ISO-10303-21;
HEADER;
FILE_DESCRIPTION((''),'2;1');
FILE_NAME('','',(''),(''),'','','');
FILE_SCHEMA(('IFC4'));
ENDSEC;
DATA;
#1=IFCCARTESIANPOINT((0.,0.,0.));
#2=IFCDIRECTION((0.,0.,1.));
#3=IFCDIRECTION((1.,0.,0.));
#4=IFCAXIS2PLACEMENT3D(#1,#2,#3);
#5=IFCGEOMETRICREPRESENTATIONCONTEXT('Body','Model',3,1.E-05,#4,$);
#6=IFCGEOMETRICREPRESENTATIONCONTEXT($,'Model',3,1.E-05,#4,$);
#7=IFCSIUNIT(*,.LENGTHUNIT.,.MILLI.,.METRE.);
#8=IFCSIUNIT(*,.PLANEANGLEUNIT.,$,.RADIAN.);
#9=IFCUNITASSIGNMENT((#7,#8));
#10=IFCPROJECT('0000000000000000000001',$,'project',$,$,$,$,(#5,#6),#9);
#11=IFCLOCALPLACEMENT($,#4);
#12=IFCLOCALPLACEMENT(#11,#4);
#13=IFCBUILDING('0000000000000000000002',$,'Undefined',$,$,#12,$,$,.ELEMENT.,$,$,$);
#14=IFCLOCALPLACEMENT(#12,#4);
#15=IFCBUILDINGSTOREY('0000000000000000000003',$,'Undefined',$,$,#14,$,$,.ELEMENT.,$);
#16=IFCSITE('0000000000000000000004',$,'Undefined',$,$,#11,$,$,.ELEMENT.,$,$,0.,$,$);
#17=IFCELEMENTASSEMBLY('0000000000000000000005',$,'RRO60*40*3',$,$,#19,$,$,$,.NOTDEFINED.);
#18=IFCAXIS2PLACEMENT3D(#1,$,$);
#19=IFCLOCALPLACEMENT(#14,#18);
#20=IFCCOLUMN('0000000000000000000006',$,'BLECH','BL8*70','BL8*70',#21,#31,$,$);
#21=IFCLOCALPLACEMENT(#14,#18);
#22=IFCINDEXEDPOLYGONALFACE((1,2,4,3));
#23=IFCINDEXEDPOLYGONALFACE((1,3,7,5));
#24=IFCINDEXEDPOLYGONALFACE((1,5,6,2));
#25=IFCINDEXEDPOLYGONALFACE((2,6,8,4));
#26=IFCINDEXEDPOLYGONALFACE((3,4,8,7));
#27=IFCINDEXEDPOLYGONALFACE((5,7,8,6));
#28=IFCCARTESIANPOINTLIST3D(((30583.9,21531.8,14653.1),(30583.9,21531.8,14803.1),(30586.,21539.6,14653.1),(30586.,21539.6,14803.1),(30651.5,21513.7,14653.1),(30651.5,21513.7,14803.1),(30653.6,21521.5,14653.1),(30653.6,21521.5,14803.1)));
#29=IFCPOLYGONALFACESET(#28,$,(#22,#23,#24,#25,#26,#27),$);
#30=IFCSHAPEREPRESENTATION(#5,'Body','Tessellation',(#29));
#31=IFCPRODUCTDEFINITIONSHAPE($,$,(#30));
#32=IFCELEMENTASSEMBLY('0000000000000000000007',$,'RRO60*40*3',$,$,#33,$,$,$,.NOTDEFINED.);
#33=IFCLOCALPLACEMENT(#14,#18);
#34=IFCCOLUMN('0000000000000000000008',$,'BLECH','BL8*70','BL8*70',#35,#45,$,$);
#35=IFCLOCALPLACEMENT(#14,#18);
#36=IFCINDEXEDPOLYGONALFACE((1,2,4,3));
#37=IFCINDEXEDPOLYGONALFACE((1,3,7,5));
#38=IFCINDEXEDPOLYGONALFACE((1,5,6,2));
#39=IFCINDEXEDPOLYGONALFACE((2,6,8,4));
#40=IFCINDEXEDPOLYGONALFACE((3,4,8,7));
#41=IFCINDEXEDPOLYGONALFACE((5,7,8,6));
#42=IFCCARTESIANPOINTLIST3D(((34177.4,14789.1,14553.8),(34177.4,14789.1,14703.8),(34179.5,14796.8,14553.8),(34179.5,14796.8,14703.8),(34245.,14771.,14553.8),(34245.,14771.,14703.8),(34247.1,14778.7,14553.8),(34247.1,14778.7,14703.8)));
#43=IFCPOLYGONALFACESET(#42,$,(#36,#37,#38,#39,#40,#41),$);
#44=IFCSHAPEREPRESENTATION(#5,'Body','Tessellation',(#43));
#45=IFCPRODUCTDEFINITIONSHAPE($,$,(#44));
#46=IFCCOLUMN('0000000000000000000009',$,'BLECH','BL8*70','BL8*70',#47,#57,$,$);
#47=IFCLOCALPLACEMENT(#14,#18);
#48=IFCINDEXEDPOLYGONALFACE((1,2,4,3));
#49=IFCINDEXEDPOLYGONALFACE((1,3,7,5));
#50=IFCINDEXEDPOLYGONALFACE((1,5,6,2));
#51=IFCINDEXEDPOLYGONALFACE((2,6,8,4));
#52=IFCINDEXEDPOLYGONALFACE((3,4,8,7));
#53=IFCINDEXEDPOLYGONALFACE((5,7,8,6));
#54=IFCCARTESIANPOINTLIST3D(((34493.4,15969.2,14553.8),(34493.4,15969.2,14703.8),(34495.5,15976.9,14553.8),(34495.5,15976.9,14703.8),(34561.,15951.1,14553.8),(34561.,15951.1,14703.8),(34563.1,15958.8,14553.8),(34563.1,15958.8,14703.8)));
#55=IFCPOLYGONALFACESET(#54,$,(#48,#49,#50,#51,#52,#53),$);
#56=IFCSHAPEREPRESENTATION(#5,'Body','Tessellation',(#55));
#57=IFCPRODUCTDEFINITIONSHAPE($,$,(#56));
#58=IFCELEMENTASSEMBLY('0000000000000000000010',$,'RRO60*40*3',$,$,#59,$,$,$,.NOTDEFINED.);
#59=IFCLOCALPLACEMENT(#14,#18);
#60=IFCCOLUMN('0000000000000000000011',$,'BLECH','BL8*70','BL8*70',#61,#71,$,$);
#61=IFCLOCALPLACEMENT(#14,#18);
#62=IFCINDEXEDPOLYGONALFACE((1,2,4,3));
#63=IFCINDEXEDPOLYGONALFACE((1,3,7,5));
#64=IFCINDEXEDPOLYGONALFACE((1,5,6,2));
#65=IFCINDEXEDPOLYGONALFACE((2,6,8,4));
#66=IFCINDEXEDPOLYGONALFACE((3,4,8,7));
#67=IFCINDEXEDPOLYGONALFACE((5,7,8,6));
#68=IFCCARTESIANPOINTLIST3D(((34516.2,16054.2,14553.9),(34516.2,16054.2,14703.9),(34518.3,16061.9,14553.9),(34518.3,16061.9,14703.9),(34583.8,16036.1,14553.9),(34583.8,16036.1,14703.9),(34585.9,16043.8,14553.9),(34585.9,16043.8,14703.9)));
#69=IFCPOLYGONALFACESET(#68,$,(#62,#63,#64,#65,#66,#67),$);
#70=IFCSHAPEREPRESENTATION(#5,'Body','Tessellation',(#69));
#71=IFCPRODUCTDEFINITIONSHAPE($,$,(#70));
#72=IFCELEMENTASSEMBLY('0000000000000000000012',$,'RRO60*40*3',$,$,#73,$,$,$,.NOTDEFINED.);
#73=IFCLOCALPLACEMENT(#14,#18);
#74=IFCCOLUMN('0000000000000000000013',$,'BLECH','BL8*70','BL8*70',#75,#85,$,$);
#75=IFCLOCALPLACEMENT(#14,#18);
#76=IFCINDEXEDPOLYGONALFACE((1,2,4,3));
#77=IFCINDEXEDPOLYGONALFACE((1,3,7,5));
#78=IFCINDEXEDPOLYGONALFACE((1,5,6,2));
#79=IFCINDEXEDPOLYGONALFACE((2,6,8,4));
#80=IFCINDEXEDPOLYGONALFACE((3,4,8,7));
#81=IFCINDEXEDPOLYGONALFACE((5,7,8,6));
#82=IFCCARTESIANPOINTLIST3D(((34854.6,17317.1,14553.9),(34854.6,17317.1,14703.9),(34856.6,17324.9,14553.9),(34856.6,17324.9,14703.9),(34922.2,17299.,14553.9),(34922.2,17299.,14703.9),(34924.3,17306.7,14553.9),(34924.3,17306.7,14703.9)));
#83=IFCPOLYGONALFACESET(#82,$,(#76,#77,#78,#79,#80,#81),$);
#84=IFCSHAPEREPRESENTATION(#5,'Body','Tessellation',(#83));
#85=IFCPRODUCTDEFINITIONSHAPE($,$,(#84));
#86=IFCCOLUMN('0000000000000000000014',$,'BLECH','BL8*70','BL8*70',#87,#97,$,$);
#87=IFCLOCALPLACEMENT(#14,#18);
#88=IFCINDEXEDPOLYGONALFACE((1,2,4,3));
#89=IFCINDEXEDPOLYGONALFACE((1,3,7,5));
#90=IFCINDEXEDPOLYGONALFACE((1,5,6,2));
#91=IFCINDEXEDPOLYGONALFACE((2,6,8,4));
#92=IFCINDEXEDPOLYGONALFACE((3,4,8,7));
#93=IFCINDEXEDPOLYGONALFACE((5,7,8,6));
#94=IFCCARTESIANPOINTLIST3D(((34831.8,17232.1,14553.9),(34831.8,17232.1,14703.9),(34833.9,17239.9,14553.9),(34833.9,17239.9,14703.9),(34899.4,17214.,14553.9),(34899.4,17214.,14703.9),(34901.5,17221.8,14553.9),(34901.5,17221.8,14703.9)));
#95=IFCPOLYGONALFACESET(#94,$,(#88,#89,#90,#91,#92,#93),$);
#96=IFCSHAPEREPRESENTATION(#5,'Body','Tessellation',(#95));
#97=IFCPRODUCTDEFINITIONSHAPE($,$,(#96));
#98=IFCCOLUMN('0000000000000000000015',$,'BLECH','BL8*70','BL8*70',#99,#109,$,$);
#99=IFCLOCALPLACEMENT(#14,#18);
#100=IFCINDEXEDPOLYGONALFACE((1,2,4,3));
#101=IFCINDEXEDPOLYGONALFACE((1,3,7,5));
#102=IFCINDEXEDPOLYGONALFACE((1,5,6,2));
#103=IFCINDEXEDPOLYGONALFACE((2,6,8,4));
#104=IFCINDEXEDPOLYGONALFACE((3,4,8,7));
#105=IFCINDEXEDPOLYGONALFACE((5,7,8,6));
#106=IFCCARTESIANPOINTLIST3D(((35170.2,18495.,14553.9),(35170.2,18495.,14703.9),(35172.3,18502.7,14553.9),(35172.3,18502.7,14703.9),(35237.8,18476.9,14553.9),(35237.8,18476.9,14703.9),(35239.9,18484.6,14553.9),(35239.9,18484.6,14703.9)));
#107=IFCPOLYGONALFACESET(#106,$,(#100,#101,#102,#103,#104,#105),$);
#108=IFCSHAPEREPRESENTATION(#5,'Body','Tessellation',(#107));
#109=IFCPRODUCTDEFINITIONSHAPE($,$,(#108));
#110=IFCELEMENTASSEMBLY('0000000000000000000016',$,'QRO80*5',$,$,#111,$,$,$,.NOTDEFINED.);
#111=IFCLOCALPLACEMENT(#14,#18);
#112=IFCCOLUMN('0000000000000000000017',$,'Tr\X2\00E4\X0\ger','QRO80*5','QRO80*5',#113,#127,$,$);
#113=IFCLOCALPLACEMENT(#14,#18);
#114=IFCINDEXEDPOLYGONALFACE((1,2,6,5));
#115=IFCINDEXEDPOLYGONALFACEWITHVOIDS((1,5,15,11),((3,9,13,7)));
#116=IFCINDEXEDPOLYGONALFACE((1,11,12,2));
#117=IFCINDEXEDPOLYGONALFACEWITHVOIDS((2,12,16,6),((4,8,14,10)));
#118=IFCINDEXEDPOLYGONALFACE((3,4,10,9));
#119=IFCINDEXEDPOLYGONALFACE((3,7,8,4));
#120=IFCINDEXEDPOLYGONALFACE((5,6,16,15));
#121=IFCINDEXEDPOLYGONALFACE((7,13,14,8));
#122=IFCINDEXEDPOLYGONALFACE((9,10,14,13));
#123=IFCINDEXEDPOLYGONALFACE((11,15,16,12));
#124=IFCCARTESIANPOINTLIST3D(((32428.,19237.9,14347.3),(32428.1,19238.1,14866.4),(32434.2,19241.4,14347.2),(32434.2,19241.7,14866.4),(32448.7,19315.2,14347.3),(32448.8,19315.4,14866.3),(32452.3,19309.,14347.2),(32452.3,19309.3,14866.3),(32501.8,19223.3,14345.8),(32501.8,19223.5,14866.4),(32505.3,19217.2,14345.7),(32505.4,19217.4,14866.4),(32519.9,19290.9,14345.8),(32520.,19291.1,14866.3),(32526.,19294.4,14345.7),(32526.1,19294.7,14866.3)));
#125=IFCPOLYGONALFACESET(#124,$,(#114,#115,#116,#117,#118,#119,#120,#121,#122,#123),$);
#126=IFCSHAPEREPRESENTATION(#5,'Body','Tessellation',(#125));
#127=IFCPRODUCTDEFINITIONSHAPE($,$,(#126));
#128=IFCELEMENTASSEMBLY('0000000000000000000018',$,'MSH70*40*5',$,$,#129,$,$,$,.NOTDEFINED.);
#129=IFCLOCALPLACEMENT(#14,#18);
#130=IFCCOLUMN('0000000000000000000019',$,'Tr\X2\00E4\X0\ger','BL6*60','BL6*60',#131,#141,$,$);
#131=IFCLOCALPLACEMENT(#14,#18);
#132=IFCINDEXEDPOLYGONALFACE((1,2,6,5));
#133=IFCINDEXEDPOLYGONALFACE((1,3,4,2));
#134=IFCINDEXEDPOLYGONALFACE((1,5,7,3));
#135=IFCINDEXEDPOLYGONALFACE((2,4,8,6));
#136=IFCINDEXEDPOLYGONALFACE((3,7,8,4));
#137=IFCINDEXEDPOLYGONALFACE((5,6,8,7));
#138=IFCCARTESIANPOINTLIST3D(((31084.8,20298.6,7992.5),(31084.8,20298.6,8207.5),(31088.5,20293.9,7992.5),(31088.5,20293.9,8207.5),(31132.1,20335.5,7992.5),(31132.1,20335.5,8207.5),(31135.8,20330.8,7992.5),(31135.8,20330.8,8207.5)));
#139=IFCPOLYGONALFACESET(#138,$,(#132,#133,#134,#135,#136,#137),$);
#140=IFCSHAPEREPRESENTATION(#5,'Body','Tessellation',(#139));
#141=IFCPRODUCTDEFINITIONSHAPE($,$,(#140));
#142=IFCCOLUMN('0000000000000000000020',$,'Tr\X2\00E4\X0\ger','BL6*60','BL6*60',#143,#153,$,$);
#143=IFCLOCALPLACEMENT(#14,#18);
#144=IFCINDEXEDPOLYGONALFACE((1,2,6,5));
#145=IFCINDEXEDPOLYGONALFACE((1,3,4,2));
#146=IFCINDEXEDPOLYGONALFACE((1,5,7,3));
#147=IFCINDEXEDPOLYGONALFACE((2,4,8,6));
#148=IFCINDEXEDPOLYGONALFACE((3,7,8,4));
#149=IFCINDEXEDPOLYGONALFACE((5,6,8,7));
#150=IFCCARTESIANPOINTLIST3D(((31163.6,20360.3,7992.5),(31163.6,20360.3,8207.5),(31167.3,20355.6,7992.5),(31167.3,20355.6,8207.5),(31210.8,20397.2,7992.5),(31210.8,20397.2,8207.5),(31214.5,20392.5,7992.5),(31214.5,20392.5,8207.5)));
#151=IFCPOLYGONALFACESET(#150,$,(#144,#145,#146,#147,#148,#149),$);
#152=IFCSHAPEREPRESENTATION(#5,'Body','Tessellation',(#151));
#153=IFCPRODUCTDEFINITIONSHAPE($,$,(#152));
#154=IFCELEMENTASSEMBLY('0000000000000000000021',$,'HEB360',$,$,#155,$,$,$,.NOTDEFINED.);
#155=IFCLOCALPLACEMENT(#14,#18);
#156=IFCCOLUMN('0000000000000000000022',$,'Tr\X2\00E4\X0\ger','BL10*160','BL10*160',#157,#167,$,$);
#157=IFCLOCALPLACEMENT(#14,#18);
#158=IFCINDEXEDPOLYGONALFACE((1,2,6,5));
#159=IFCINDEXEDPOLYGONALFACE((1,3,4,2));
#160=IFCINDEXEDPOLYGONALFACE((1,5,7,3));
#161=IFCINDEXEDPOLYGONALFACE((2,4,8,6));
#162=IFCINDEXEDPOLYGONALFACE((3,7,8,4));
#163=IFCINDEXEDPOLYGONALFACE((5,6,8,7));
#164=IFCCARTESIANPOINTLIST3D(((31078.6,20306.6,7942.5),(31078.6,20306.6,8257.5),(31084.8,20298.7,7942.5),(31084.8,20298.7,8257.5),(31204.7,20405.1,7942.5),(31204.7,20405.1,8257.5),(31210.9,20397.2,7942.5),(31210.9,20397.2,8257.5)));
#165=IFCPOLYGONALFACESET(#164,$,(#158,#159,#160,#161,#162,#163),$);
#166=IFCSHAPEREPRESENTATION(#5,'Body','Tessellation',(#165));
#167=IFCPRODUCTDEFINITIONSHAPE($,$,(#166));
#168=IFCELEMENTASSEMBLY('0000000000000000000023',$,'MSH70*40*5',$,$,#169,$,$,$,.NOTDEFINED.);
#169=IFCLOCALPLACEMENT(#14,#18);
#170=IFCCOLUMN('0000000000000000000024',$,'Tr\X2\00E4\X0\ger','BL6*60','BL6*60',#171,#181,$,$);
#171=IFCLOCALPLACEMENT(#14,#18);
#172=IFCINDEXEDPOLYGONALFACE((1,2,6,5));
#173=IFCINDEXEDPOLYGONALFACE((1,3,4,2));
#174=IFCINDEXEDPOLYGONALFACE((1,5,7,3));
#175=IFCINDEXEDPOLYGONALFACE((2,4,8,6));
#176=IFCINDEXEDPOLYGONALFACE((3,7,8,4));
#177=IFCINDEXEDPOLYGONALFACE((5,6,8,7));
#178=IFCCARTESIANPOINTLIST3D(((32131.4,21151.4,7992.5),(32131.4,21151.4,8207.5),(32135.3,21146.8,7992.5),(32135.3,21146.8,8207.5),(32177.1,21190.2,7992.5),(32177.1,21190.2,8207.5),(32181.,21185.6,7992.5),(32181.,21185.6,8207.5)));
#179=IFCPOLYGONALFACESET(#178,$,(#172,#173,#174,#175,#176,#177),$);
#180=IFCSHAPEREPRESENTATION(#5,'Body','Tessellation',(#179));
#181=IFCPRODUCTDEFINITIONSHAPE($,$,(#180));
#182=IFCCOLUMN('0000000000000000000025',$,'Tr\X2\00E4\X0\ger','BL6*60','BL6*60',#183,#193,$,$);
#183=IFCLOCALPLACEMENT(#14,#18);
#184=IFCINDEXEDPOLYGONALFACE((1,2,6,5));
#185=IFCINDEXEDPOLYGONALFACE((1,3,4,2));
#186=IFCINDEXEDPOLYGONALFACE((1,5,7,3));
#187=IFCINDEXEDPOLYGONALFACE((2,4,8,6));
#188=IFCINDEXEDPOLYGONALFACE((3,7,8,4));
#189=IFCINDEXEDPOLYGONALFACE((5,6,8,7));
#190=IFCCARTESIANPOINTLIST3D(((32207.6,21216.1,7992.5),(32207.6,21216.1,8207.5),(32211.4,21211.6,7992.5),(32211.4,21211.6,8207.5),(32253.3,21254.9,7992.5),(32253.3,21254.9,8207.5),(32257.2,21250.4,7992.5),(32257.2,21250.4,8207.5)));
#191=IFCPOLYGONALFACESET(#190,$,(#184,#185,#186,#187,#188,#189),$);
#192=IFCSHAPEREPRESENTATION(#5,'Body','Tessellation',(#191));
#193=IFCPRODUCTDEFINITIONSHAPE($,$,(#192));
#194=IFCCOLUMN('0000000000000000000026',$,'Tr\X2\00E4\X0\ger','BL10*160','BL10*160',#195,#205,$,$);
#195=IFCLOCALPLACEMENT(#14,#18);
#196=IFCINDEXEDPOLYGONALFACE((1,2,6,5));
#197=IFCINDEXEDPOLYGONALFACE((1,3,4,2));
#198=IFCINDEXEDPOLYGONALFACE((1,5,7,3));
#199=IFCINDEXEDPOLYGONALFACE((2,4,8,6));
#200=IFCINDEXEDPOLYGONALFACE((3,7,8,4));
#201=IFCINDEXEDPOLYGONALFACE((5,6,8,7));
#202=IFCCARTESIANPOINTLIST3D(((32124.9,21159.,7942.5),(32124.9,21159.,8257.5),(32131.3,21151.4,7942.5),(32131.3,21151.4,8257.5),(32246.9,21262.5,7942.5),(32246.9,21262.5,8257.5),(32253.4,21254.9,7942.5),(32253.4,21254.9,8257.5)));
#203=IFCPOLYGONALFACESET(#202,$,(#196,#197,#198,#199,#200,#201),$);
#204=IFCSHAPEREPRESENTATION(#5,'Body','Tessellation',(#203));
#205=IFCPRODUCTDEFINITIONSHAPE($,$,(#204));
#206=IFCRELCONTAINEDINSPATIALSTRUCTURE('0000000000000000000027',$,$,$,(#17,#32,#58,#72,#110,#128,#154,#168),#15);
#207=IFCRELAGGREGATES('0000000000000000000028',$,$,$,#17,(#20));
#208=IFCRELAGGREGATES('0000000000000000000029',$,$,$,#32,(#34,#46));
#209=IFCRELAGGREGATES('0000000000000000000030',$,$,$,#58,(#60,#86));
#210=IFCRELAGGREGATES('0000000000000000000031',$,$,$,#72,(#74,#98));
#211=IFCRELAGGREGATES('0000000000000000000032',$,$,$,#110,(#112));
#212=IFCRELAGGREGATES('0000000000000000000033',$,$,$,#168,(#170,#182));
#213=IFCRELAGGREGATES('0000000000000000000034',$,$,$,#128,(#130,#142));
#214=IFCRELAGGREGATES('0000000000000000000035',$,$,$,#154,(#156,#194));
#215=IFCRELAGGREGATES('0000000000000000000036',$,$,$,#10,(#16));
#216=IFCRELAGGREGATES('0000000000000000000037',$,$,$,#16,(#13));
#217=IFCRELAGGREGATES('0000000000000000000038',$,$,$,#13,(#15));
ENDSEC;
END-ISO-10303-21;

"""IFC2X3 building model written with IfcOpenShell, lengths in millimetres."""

from ifc_helpers import new_model, si_unit, frame, origin_with_axes, origin_2d_with_axis, place, context, project, spatial, rectangle, hollow_rectangle, extrude, clip, halfspace, element, aggregate, save


model = new_model("IFC2X3")

# Units and contexts
model_context_1 = context("Model", 3, precision=1e-05, world=origin_with_axes(), identifier="Body")
model_context_2 = context("Model", 3, precision=1e-05, world=origin_with_axes())
ifc_project = project(units=[si_unit("LENGTHUNIT", "METRE", prefix="MILLI"), si_unit("PLANEANGLEUNIT", "RADIAN")], contexts=[model_context_1, model_context_2])

# Site, building, storey
site_placement = place(None, origin_with_axes())
site = spatial("IfcSite", under=ifc_project, at=site_placement, Name="Undefined", CompositionType="ELEMENT", RefElevation=0.0)
building_placement = place(site_placement, origin_with_axes())
building = spatial("IfcBuilding", under=site, at=building_placement, Name="Undefined", CompositionType="ELEMENT")
storey_placement = place(building_placement, origin_with_axes())
storey = spatial("IfcBuildingStorey", under=building, at=storey_placement, Name="Undefined", CompositionType="ELEMENT")

# Element assembly, column
assembly_1 = element("IfcElementAssembly", 1, inside=storey, Name="RRO60*40*3", PredefinedType="NOTDEFINED")
column_1_placement = place(storey_placement, frame((30618.7, 21526.7, 14653.1), z_axis=(0.0, 0.0, 1.0), x_axis=(1.0, 0.0, 0.0)))
column_1 = element("IfcColumn", 2, at=column_1_placement, Name="BLECH", Description="BL8*70", ObjectType="BL8*70", context=model_context_1, shape_type="SweptSolid", body=[
    extrude(rectangle(XDim=8.0, YDim=70.0, at=origin_2d_with_axis()), frame((0.0, 0.0, 150.0), z_axis=(0.0, 0.0, -1.0), x_axis=(0.258806, 0.965929, -0.000007)), (0.0, 0.0, 1.0), 150.0),
])
aggregate(assembly_1, [column_1])

# Element assembly, columns
assembly_2 = element("IfcElementAssembly", 3, inside=storey, Name="RRO60*40*3", PredefinedType="NOTDEFINED")
column_2_placement = place(storey_placement, frame((34212.3, 14783.9, 14553.8), z_axis=(0.0, 0.0, 1.0), x_axis=(1.0, 0.0, 0.0)))
column_2 = element("IfcColumn", 4, at=column_2_placement, Name="BLECH", Description="BL8*70", ObjectType="BL8*70", context=model_context_1, shape_type="SweptSolid", body=[
    extrude(rectangle(XDim=8.0, YDim=70.0, at=origin_2d_with_axis()), frame((0.0, 0.0, 150.0), z_axis=(0.0, 0.0, -1.0), x_axis=(0.258667, 0.965967, 0.000006)), (0.0, 0.0, 1.0), 150.0),
])
column_3_placement = place(storey_placement, frame((34528.3, 15964.0, 14553.8), z_axis=(0.0, 0.0, 1.0), x_axis=(1.0, 0.0, 0.0)))
column_3 = element("IfcColumn", 5, at=column_3_placement, Name="BLECH", Description="BL8*70", ObjectType="BL8*70", context=model_context_1, shape_type="SweptSolid", body=[
    extrude(rectangle(XDim=8.0, YDim=70.0, at=origin_2d_with_axis()), frame((0.0, 0.0, 150.0), z_axis=(0.0, 0.0, -1.0), x_axis=(-0.258667, -0.965967, -0.000006)), (0.0, 0.0, 1.0), 150.0),
])
aggregate(assembly_2, [column_2, column_3])

# Element assemblies, columns
assembly_3 = element("IfcElementAssembly", 6, inside=storey, Name="RRO60*40*3", PredefinedType="NOTDEFINED")
column_4_placement = place(storey_placement, frame((34551.0, 16049.0, 14553.9), z_axis=(0.0, 0.0, 1.0), x_axis=(1.0, 0.0, 0.0)))
column_4 = element("IfcColumn", 7, at=column_4_placement, Name="BLECH", Description="BL8*70", ObjectType="BL8*70", context=model_context_1, shape_type="SweptSolid", body=[
    extrude(rectangle(XDim=8.0, YDim=70.0, at=origin_2d_with_axis()), frame((0.0, 0.0, 150.0), z_axis=(0.0, 0.0, -1.0), x_axis=(0.258822, 0.965925, 0.000005)), (0.0, 0.0, 1.0), 150.0),
])
assembly_4 = element("IfcElementAssembly", 8, inside=storey, Name="RRO60*40*3", PredefinedType="NOTDEFINED")
column_5_placement = place(storey_placement, frame((34889.4, 17311.9, 14553.9), z_axis=(0.0, 0.0, 1.0), x_axis=(1.0, 0.0, 0.0)))
column_5 = element("IfcColumn", 9, at=column_5_placement, Name="BLECH", Description="BL8*70", ObjectType="BL8*70", context=model_context_1, shape_type="SweptSolid", body=[
    extrude(rectangle(XDim=8.0, YDim=70.0, at=origin_2d_with_axis()), frame((0.0, 0.0, 150.0), z_axis=(0.0, 0.0, -1.0), x_axis=(0.258822, 0.965925, 0.000005)), (0.0, 0.0, 1.0), 150.0),
])

# Columns
column_6_placement = place(storey_placement, frame((34866.7, 17227.0, 14553.9), z_axis=(0.0, 0.0, 1.0), x_axis=(1.0, 0.0, 0.0)))
column_6 = element("IfcColumn", 10, at=column_6_placement, Name="BLECH", Description="BL8*70", ObjectType="BL8*70", context=model_context_1, shape_type="SweptSolid", body=[
    extrude(rectangle(XDim=8.0, YDim=70.0, at=origin_2d_with_axis()), frame((0.0, 0.0, 150.0), z_axis=(0.0, 0.0, -1.0), x_axis=(-0.258822, -0.965925, -0.000005)), (0.0, 0.0, 1.0), 150.0),
])
aggregate(assembly_3, [column_4, column_6])
column_7_placement = place(storey_placement, frame((35205.0, 18489.8, 14553.9), z_axis=(0.0, 0.0, 1.0), x_axis=(1.0, 0.0, 0.0)))
column_7 = element("IfcColumn", 11, at=column_7_placement, Name="BLECH", Description="BL8*70", ObjectType="BL8*70", context=model_context_1, shape_type="SweptSolid", body=[
    extrude(rectangle(XDim=8.0, YDim=70.0, at=origin_2d_with_axis()), frame((0.0, 0.0, 150.0), z_axis=(0.0, 0.0, -1.0), x_axis=(-0.258822, -0.965925, -0.000005)), (0.0, 0.0, 1.0), 150.0),
])
aggregate(assembly_4, [column_5, column_7])

# Element assembly, column
assembly_5 = element("IfcElementAssembly", 12, inside=storey, Name="QRO80*5", PredefinedType="NOTDEFINED")
column_8_placement = place(storey_placement, frame((32477.0, 19266.2, 14354.9), z_axis=(0.0, 0.0, 1.0), x_axis=(1.0, 0.0, 0.0)))
column_8 = element("IfcColumn", 13, at=column_8_placement, Name="Träger", Description="QRO80*5", ObjectType="QRO80*5", context=model_context_1, shape_type="Clipping", body=[
    clip(clip(extrude(hollow_rectangle(XDim=80.0, YDim=80.0, WallThickness=5.0, at=origin_2d_with_axis()), frame((0.1, 0.2, 511.5), z_axis=(-0.000121, -0.00046, -1.0), x_axis=(-0.258925, -0.965897, 0.000475)), (0.0, 0.0, 1.0), 520.7), halfspace(frame((38.6, -10.4, -9.1), z_axis=(0.018515, -0.004961, 0.999816), x_axis=(-0.258932, -0.965896, 0.000006)), True)), halfspace(frame((38.7, -10.1, 511.5), z_axis=(0.0, 0.0, -1.0), x_axis=(0.258822, 0.965925, 0.000005)), True)),
])
aggregate(assembly_5, [column_8])

# Element assembly, columns
assembly_6 = element("IfcElementAssembly", 14, inside=storey, Name="MSH70*40*5", PredefinedType="NOTDEFINED")
column_9_placement = place(storey_placement, frame((31110.3, 20314.7, 7992.5), z_axis=(0.0, 0.0, 1.0), x_axis=(1.0, 0.0, 0.0)))
column_9 = element("IfcColumn", 15, at=column_9_placement, Name="Träger", Description="BL6*60", ObjectType="BL6*60", context=model_context_1, shape_type="SweptSolid", body=[
    extrude(rectangle(XDim=6.0, YDim=60.0, at=origin_2d_with_axis()), frame((0.0, 0.0, 215.0), z_axis=(0.0, 0.0, -1.0), x_axis=(0.615661, -0.788011, 0.0)), (0.0, 0.0, 1.0), 215.0),
])
column_10_placement = place(storey_placement, frame((31189.0, 20376.4, 7992.5), z_axis=(0.0, 0.0, 1.0), x_axis=(1.0, 0.0, 0.0)))
column_10 = element("IfcColumn", 16, at=column_10_placement, Name="Träger", Description="BL6*60", ObjectType="BL6*60", context=model_context_1, shape_type="SweptSolid", body=[
    extrude(rectangle(XDim=6.0, YDim=60.0, at=origin_2d_with_axis()), frame((0.0, 0.0, 215.0), z_axis=(0.0, 0.0, -1.0), x_axis=(0.615661, -0.788011, 0.0)), (0.0, 0.0, 1.0), 215.0),
])

# Element assembly, column
assembly_7 = element("IfcElementAssembly", 17, inside=storey, Name="HEB360", PredefinedType="NOTDEFINED")
column_11_placement = place(storey_placement, frame((31144.8, 20351.9, 7942.5), z_axis=(0.0, 0.0, 1.0), x_axis=(1.0, 0.0, 0.0)))
column_11 = element("IfcColumn", 18, at=column_11_placement, Name="Träger", Description="BL10*160", ObjectType="BL10*160", context=model_context_1, shape_type="SweptSolid", body=[
    extrude(rectangle(XDim=10.0, YDim=160.0, at=origin_2d_with_axis()), frame((0.0, 0.0, 315.0), z_axis=(0.0, 0.0, -1.0), x_axis=(0.615661, -0.788011, 0.0)), (0.0, 0.0, 1.0), 315.0),
])

# Element assembly, columns
assembly_8 = element("IfcElementAssembly", 19, inside=storey, Name="MSH70*40*5", PredefinedType="NOTDEFINED")
column_12_placement = place(storey_placement, frame((32156.2, 21168.5, 7992.5), z_axis=(0.0, 0.0, 1.0), x_axis=(1.0, 0.0, 0.0)))
column_12 = element("IfcColumn", 20, at=column_12_placement, Name="Träger", Description="BL6*60", ObjectType="BL6*60", context=model_context_1, shape_type="SweptSolid", body=[
    extrude(rectangle(XDim=6.0, YDim=60.0, at=origin_2d_with_axis()), frame((0.0, 0.0, 215.0), z_axis=(0.0, 0.0, -1.0), x_axis=(0.64679, -0.762668, 0.0)), (0.0, 0.0, 1.0), 215.0),
])
column_13_placement = place(storey_placement, frame((32232.4, 21233.3, 7992.5), z_axis=(0.0, 0.0, 1.0), x_axis=(1.0, 0.0, 0.0)))
column_13 = element("IfcColumn", 21, at=column_13_placement, Name="Träger", Description="BL6*60", ObjectType="BL6*60", context=model_context_1, shape_type="SweptSolid", body=[
    extrude(rectangle(XDim=6.0, YDim=60.0, at=origin_2d_with_axis()), frame((0.0, 0.0, 215.0), z_axis=(0.0, 0.0, -1.0), x_axis=(0.64679, -0.762668, 0.0)), (0.0, 0.0, 1.0), 215.0),
])

# Column
column_14_placement = place(storey_placement, frame((32189.1, 21207.0, 7942.5), z_axis=(0.0, 0.0, 1.0), x_axis=(1.0, 0.0, 0.0)))
column_14 = element("IfcColumn", 22, at=column_14_placement, Name="Träger", Description="BL10*160", ObjectType="BL10*160", context=model_context_1, shape_type="SweptSolid", body=[
    extrude(rectangle(XDim=10.0, YDim=160.0, at=origin_2d_with_axis()), frame((0.0, 0.0, 315.0), z_axis=(0.0, 0.0, -1.0), x_axis=(0.64679, -0.762668, 0.0)), (0.0, 0.0, 1.0), 315.0),
])
aggregate(assembly_8, [column_12, column_13])
aggregate(assembly_6, [column_9, column_10])
aggregate(assembly_7, [column_11, column_14])

save(model, "model.ifc")
